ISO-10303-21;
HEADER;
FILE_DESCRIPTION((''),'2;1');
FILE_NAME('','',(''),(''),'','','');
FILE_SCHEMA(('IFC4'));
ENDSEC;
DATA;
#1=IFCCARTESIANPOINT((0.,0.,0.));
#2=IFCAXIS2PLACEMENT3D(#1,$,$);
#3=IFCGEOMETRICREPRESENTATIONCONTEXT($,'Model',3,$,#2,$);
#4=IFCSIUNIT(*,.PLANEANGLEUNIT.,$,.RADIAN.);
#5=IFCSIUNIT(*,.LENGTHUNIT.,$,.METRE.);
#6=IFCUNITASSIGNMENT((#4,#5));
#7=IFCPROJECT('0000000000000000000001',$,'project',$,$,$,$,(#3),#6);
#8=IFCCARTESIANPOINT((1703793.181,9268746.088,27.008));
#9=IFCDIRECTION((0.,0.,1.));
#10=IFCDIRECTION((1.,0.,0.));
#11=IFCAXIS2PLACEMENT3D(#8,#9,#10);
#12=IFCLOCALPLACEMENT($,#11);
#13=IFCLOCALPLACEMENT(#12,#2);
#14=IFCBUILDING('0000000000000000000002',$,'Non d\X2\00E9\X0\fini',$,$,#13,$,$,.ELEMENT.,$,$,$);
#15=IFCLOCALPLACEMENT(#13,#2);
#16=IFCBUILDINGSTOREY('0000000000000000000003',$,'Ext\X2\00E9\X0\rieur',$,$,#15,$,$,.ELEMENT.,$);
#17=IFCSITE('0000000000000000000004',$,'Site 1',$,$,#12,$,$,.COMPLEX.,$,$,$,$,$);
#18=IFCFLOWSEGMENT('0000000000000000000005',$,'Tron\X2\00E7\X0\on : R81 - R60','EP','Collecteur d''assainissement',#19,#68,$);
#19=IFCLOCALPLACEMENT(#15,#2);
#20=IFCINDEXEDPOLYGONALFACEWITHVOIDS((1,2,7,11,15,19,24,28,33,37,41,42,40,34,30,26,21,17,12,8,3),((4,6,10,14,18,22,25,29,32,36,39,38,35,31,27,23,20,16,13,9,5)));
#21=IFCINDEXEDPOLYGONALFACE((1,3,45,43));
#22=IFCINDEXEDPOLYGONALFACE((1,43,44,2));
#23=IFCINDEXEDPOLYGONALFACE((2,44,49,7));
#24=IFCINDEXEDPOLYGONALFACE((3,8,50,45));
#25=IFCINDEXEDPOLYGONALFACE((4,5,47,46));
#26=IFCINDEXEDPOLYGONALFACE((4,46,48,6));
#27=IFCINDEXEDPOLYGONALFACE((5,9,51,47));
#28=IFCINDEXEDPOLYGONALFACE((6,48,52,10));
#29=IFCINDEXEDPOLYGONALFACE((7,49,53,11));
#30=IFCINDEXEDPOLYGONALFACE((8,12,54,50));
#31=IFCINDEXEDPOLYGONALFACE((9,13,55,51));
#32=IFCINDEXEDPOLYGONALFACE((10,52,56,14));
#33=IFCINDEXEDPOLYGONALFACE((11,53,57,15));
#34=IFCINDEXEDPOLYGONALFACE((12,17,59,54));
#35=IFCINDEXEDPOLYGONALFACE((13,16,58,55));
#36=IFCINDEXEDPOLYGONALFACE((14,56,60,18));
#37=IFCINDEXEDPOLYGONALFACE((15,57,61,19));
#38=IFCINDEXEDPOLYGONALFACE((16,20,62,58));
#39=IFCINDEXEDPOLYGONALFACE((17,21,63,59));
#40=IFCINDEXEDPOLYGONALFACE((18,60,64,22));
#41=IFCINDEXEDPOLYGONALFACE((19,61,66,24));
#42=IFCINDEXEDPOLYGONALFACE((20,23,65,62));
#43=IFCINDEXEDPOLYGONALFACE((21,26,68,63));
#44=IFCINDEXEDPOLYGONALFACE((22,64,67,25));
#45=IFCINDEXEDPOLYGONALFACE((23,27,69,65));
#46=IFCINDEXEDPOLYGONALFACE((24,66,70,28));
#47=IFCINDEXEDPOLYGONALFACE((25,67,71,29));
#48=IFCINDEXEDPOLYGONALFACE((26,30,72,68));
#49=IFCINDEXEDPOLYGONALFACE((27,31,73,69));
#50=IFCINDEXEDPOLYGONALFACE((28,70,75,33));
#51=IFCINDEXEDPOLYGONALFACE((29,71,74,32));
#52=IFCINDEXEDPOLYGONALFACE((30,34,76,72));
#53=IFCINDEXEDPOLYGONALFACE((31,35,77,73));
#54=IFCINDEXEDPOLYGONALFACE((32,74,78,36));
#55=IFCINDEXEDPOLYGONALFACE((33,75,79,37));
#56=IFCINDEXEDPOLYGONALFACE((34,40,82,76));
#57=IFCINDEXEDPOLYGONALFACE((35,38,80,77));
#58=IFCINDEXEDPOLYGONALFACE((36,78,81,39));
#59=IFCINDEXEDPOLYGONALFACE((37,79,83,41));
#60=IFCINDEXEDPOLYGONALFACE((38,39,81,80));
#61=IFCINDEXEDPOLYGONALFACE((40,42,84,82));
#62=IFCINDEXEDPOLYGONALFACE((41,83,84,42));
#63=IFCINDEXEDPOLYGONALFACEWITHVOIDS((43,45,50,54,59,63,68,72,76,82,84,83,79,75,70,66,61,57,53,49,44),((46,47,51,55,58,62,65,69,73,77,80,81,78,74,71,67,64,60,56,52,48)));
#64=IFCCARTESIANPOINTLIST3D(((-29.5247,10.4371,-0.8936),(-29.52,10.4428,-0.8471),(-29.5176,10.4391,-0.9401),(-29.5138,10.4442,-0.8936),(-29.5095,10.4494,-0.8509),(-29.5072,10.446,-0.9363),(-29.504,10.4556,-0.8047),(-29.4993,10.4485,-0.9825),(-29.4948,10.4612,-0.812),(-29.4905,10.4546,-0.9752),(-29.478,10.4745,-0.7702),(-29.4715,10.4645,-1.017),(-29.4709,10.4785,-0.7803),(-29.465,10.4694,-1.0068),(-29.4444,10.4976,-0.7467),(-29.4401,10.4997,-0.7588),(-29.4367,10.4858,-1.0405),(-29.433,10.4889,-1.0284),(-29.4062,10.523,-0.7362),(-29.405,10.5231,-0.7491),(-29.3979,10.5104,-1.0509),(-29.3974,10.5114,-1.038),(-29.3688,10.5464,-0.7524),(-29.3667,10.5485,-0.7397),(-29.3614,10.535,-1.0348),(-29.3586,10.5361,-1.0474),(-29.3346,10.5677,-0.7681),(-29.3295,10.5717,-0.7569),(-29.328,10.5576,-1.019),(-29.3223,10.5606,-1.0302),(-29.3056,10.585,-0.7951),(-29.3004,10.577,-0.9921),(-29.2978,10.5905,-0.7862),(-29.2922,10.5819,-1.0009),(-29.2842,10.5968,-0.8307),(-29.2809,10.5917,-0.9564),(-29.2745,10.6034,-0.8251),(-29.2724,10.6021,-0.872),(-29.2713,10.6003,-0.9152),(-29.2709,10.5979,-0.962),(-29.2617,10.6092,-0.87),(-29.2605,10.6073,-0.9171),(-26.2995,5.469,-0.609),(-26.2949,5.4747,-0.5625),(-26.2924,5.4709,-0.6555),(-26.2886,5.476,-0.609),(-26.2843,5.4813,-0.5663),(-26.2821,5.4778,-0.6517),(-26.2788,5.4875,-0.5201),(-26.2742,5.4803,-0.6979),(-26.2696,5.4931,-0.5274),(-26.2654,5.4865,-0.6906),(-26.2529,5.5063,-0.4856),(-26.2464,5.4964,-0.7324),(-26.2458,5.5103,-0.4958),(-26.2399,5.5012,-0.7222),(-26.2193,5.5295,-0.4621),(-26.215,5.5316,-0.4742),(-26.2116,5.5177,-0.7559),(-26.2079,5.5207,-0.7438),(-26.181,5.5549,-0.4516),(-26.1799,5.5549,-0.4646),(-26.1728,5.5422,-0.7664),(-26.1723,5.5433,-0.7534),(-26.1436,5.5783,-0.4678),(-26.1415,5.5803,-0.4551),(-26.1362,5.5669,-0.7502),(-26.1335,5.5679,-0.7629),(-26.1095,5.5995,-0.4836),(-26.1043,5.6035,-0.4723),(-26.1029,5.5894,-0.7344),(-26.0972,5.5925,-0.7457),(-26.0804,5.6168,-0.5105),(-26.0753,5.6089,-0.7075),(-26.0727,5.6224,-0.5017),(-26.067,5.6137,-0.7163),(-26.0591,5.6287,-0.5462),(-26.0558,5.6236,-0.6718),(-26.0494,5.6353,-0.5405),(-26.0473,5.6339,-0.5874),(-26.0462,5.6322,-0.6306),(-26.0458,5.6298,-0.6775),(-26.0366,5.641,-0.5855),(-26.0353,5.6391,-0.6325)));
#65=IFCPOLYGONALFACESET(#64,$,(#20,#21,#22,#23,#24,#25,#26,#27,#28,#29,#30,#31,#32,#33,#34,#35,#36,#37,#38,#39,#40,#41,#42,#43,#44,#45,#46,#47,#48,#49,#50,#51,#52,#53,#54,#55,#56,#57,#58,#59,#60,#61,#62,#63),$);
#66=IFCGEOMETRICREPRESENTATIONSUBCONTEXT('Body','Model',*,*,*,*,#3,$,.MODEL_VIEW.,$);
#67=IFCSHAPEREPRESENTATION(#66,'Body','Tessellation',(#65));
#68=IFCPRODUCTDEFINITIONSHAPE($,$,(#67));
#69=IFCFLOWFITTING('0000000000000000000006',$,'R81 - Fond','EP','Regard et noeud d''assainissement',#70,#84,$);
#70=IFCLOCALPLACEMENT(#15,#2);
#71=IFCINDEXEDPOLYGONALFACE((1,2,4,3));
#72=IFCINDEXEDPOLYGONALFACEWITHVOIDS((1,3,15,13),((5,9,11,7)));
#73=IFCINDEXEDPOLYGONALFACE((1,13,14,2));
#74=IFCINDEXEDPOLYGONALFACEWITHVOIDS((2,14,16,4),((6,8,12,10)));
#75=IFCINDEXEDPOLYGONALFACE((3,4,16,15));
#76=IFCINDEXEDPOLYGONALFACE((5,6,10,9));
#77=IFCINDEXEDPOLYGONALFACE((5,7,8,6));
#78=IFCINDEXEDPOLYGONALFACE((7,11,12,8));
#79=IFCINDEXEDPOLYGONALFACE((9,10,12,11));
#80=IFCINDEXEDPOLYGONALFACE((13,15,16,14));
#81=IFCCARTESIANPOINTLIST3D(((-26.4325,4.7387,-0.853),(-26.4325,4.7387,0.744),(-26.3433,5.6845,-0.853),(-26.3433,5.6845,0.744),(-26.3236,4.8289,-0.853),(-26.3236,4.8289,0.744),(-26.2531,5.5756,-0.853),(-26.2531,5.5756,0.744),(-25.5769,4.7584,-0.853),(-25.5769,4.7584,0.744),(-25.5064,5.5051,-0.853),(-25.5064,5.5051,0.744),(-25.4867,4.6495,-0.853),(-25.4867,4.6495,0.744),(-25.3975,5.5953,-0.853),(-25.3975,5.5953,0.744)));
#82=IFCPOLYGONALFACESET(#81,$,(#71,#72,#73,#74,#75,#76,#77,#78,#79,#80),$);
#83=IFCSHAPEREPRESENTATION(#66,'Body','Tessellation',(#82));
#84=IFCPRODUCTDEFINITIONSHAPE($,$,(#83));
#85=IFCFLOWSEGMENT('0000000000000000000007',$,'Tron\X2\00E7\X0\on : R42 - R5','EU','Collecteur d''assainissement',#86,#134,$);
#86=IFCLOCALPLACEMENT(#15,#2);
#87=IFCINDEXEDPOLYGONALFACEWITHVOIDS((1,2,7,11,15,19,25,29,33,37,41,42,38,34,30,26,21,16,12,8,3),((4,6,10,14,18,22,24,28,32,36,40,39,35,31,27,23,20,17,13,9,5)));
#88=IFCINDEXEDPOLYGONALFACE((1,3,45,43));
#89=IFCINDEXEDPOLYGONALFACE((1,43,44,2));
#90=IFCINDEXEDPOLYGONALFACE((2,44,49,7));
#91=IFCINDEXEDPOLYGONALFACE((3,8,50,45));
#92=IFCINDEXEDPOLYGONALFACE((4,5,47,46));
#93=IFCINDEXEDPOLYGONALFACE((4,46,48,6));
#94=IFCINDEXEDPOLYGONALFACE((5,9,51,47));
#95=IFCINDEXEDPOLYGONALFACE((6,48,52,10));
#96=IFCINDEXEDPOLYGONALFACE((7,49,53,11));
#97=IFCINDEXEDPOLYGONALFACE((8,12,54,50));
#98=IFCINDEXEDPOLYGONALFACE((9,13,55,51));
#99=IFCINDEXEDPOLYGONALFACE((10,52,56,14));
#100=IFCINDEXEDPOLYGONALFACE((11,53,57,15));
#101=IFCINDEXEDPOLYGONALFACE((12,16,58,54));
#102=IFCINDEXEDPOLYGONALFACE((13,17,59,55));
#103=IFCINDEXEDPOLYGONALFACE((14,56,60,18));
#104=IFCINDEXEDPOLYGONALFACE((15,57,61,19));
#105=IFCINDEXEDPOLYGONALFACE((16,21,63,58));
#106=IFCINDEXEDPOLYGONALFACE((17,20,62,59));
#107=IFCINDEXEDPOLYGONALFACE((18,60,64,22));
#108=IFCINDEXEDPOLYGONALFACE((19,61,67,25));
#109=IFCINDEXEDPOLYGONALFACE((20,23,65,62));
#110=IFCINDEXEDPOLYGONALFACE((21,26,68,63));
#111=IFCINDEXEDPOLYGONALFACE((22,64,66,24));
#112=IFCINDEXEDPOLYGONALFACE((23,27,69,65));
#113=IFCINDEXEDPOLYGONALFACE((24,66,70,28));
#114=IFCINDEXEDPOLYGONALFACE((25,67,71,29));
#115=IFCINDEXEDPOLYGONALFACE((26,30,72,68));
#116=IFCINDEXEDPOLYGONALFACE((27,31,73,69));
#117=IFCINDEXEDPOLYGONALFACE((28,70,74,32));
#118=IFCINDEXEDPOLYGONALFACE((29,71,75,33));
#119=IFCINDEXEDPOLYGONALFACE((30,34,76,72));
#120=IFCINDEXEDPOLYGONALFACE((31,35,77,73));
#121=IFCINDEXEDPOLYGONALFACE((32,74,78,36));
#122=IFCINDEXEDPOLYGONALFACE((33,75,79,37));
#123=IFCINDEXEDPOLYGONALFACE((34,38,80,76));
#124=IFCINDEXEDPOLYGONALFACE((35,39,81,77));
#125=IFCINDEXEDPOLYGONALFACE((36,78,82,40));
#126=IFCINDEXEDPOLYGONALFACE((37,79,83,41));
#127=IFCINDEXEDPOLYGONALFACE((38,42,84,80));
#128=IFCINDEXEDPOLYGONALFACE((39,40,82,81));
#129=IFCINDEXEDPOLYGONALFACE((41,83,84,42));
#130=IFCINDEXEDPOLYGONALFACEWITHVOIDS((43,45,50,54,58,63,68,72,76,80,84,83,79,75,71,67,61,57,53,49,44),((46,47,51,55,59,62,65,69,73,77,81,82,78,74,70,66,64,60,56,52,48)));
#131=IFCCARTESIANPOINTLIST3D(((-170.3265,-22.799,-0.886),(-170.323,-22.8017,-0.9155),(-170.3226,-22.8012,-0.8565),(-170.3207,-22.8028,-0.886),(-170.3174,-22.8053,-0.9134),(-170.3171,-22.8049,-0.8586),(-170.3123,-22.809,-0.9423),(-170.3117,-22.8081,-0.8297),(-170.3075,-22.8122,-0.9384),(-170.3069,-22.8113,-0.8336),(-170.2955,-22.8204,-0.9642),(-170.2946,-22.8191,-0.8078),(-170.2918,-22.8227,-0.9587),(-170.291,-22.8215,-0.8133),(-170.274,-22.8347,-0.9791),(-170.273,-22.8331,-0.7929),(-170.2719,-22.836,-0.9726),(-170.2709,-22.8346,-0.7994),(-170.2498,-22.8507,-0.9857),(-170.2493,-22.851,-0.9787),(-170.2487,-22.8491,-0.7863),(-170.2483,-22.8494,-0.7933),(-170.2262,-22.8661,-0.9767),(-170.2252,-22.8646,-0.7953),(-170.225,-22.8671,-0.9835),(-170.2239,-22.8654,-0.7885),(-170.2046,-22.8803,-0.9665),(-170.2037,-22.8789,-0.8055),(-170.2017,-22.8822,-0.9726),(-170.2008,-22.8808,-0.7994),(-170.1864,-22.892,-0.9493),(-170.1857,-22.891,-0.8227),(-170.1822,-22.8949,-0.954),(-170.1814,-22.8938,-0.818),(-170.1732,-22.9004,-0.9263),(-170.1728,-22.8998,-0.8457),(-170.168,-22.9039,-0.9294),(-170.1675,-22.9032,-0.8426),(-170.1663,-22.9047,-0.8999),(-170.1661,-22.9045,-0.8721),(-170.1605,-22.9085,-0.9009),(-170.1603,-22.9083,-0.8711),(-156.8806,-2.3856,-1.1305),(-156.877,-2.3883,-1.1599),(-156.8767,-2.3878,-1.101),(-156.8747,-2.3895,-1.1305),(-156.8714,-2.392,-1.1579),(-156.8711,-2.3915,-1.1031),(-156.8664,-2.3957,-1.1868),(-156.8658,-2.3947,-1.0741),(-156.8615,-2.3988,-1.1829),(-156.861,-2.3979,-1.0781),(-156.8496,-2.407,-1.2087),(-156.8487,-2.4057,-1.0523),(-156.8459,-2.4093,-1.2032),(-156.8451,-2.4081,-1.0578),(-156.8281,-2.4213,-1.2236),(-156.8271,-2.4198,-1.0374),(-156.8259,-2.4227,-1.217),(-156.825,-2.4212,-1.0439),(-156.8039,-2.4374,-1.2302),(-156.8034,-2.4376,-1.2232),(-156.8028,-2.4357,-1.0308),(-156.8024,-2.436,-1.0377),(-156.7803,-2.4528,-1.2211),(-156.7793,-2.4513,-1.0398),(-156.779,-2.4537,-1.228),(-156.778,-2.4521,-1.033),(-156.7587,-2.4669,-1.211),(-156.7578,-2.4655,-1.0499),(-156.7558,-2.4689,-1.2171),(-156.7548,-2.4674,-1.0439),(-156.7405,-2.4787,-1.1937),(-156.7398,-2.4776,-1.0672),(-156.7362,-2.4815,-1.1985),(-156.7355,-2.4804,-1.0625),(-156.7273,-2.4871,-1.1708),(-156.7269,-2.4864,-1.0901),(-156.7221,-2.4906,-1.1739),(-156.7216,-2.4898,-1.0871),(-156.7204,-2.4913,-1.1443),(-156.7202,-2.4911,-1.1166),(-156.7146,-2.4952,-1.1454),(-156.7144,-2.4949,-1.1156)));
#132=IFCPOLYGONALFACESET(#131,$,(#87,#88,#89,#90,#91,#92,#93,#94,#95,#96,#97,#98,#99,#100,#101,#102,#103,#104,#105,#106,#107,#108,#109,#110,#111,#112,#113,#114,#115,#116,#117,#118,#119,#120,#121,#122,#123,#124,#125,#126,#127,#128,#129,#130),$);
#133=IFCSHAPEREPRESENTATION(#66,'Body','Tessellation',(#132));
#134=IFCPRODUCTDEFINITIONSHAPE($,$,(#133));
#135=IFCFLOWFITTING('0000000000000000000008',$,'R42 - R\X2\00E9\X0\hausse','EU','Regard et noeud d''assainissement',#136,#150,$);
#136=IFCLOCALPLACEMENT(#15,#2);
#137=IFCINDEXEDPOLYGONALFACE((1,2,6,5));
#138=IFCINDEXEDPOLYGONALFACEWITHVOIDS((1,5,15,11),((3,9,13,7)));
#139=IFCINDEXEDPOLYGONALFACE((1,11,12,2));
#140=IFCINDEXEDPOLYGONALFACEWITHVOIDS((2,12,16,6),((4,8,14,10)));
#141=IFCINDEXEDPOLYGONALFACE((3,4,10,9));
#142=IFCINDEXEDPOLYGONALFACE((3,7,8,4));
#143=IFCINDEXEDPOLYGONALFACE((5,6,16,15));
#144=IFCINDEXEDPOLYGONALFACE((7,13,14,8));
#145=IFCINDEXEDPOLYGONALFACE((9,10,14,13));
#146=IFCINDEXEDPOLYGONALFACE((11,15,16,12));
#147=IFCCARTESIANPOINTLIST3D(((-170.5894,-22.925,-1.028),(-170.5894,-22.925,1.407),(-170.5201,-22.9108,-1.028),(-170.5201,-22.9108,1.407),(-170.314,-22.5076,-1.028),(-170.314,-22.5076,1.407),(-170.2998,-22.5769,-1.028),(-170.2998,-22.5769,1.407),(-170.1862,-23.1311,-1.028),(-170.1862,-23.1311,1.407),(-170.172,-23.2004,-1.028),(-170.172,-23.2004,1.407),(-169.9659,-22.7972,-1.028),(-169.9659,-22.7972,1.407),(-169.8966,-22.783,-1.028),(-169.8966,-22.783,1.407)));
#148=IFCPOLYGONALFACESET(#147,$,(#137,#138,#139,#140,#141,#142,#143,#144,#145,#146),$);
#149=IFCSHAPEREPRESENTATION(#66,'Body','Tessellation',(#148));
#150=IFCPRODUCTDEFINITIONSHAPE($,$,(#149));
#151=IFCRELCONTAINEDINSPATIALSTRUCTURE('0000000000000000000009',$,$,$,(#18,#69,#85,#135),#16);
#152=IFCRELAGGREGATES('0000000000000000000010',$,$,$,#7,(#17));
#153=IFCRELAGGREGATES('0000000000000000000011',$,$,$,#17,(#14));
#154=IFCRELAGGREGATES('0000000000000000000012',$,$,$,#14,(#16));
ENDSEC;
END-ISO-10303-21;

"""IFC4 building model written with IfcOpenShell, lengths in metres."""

from ifc_helpers import new_model, si_unit, frame, origin, origin_2d, place, context, subcontext, project, spatial, hollow_rectangle, hollow_circle, extrude, element, save


model = new_model("IFC4")

# Units and contexts
model_context = context("Model", 3, world=origin())
body_context = subcontext(model_context, "Body", "Model", "MODEL_VIEW")
ifc_project = project(units=[si_unit("PLANEANGLEUNIT", "RADIAN"), si_unit("LENGTHUNIT", "METRE")], contexts=[model_context])

# Site, building, storey
site_placement = place(None, frame((1703793.181, 9268746.088, 27.008), z_axis=(0.0, 0.0, 1.0), x_axis=(1.0, 0.0, 0.0)))
site = spatial("IfcSite", under=ifc_project, at=site_placement, Name="Site 1", CompositionType="COMPLEX")
building_placement = place(site_placement, origin())
building = spatial("IfcBuilding", under=site, at=building_placement, Name="Non défini", CompositionType="ELEMENT")
storey_placement = place(building_placement, origin())
storey = spatial("IfcBuildingStorey", under=building, at=storey_placement, Name="Extérieur", CompositionType="ELEMENT")

# Flow segment
flow_segment_1_placement = place(storey_placement, origin())
element("IfcFlowSegment", 1, at=flow_segment_1_placement, inside=storey, Name="Tronçon : R81 - R60", Description="EP", ObjectType="Collecteur d'assainissement", context=body_context, shape_type="SweptSolid", body=[
    extrude(hollow_circle(Radius=0.158, WallThickness=0.013, at=origin_2d()), frame((-26.167, 5.555, -0.609), z_axis=(-0.544, 0.838, -0.048), x_axis=(-0.838, -0.545, 0.0)), (0.0, 0.0, 1.0), 5.93),
])

# Flow fitting
flow_fitting_1_placement = place(storey_placement, origin())
element("IfcFlowFitting", 2, at=flow_fitting_1_placement, inside=storey, Name="R81 - Fond", Description="EP", ObjectType="Regard et noeud d'assainissement", context=body_context, shape_type="SweptSolid", body=[
    extrude(hollow_rectangle(XDim=0.95, YDim=0.95, WallThickness=0.1, at=origin_2d()), frame((-25.915, 5.167, -0.853), z_axis=(0.0, 0.0, 1.0), x_axis=(-0.094, -0.996, 0.0)), (0.0, 0.0, 1.0), 1.597),
])

# Flow segment
flow_segment_2_placement = place(storey_placement, origin())
element("IfcFlowSegment", 3, at=flow_segment_2_placement, inside=storey, Name="Tronçon : R42 - R5", Description="EU", ObjectType="Collecteur d'assainissement", context=body_context, shape_type="SweptSolid", body=[
    extrude(hollow_circle(Radius=0.1, WallThickness=0.007, at=origin_2d()), frame((-170.243, -22.854, -0.886), z_axis=(0.55, 0.835, -0.01), x_axis=(-0.835, 0.551, 0.0)), (0.0, 0.0, 1.0), 24.445),
])

# Flow fitting
for number, where, name in (
    (4, (0.0, 0.0, 0.0), "R42 - Réhausse"),
):
    element("IfcFlowFitting", number, at=place(storey_placement, frame(where)), inside=storey, Name=name, Description="EU", ObjectType="Regard et noeud d'assainissement", context=body_context, shape_type="SweptSolid", body=[
        extrude(hollow_rectangle(XDim=0.5, YDim=0.5, WallThickness=0.05, at=origin_2d()), frame((-170.243, -22.854, -1.028), z_axis=(0.0, 0.0, 1.0), x_axis=(0.551, 0.835, 0.0)), (0.0, 0.0, 1.0), 2.435),
    ])

save(model, "model.ifc")
